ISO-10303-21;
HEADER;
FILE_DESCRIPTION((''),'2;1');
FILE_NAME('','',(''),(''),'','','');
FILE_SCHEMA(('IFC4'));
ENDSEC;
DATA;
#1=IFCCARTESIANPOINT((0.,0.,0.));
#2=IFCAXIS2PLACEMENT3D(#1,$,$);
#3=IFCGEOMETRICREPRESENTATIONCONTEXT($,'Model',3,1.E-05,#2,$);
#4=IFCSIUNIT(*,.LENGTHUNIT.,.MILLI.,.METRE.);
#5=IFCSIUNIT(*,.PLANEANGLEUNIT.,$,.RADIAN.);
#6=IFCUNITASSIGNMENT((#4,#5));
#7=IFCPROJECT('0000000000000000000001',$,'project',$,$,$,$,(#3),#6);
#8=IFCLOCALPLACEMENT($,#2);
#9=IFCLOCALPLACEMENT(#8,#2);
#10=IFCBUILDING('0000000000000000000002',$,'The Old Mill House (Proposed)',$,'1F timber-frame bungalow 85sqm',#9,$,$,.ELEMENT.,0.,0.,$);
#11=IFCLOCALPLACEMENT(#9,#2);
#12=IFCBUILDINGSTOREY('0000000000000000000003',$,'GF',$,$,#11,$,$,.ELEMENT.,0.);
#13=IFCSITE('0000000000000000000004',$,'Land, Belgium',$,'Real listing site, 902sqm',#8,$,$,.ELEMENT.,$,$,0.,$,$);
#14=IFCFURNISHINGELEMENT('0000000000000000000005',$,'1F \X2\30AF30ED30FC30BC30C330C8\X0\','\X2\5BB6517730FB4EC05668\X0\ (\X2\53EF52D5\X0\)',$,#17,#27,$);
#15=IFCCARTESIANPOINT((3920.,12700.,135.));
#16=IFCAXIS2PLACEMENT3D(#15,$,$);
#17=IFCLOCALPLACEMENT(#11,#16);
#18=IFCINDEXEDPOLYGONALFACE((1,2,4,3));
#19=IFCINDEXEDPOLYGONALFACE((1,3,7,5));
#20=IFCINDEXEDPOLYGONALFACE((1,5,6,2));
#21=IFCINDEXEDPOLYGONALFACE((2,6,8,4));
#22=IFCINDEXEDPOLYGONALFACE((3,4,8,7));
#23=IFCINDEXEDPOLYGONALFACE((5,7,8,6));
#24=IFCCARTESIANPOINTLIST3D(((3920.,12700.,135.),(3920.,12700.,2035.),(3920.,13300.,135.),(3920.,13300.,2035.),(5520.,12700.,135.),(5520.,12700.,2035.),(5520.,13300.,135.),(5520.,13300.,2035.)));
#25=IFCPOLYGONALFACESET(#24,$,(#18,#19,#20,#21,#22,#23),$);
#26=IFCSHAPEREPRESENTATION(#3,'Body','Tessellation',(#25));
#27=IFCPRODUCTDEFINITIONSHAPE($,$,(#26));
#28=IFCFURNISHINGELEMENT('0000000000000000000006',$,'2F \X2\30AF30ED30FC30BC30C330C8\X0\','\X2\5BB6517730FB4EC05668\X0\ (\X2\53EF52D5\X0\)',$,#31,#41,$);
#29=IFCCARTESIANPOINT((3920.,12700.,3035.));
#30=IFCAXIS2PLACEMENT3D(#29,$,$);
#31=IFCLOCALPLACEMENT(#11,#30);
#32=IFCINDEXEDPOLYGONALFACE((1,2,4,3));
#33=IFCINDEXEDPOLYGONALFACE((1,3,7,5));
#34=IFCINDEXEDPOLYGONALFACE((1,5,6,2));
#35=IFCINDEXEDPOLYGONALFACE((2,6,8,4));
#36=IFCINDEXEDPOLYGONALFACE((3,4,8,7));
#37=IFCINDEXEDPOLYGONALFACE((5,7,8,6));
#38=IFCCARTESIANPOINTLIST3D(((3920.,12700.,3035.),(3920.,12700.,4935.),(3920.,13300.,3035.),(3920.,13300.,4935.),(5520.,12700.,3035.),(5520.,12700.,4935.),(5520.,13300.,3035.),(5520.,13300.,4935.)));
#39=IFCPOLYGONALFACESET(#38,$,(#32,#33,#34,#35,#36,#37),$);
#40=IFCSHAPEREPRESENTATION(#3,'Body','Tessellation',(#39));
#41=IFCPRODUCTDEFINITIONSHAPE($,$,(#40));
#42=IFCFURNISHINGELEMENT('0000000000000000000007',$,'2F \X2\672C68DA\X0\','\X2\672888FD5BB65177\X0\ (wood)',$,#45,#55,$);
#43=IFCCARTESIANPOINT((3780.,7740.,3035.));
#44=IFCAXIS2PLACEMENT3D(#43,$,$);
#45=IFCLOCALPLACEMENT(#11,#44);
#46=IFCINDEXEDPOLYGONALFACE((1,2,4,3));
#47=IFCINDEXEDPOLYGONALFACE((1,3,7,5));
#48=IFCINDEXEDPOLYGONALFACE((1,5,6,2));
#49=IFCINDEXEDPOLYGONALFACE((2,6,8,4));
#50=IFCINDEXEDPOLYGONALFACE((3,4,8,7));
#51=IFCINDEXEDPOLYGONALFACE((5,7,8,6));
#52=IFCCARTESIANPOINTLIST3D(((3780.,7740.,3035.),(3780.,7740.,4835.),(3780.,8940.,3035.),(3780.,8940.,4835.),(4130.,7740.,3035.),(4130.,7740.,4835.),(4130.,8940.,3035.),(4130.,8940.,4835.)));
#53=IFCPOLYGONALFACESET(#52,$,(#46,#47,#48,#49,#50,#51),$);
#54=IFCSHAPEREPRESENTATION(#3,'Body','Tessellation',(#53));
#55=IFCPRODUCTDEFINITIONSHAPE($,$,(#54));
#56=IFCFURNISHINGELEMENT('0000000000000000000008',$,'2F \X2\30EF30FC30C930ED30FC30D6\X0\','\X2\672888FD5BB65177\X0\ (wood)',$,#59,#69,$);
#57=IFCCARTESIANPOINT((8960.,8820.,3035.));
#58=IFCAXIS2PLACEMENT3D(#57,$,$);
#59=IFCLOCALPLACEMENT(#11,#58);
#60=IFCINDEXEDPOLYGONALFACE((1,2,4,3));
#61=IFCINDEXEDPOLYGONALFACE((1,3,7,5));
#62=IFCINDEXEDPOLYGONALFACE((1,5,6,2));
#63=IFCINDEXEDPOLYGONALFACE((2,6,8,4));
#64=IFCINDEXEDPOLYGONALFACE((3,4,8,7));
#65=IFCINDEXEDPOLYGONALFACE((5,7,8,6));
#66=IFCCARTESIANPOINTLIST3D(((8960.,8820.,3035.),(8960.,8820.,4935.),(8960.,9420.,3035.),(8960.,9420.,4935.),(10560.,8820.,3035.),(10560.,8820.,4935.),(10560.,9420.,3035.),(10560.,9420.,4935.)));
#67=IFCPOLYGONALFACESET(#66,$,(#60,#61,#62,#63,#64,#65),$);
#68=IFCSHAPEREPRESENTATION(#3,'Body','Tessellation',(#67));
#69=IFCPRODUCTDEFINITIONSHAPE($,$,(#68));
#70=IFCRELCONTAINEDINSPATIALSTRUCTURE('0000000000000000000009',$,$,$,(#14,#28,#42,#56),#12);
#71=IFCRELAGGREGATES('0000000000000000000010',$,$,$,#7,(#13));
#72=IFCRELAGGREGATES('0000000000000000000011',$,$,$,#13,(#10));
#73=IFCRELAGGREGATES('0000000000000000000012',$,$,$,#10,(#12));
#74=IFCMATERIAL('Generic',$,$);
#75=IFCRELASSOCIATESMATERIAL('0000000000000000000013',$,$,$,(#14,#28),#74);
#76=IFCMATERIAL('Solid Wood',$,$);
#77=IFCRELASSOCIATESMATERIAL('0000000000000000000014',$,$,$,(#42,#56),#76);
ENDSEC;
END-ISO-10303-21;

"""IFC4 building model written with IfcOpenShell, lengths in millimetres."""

from ifc_helpers import new_model, si_unit, frame, frame_2d, origin, place, context, project, spatial, rectangle, extrude, material, element, save


model = new_model("IFC4")

# Units and contexts
model_context = context("Model", 3, precision=1e-05, world=origin())
ifc_project = project(units=[si_unit("LENGTHUNIT", "METRE", prefix="MILLI"), si_unit("PLANEANGLEUNIT", "RADIAN")], contexts=[model_context])

# Site, building, storey
site_placement = place(None, origin())
site = spatial("IfcSite", under=ifc_project, at=site_placement, Name="Land, Belgium", ObjectType="Real listing site, 902sqm", CompositionType="ELEMENT", RefElevation=0.0)
building_placement = place(site_placement, origin())
building = spatial("IfcBuilding", under=site, at=building_placement, Name="The Old Mill House (Proposed)", ObjectType="1F timber-frame bungalow 85sqm", CompositionType="ELEMENT", ElevationOfRefHeight=0.0, ElevationOfTerrain=0.0)
storey_placement = place(building_placement, origin())
storey = spatial("IfcBuildingStorey", under=building, at=storey_placement, Name="GF", CompositionType="ELEMENT", Elevation=0.0)

# Shared definitions
ifc_material_1 = material(Name="Solid Wood")

# Shared definitions
ifc_material_2 = material(Name="Generic")

# Furnishing elements
furnishing_1_placement = place(storey_placement, frame((3920.0, 12700.0, 135.0)))
element("IfcFurnishingElement", 1, at=furnishing_1_placement, inside=storey, material=ifc_material_2, Name="1F クローゼット", Description="家具・什器 (可動)", context=model_context, shape_type="SweptSolid", body=[
    extrude(rectangle(XDim=1600.0, YDim=600.0, at=frame_2d((800.0, 300.0))), frame((3920.0, 12700.0, 135.0)), (0.0, 0.0, 1.0), 1900.0),
])
furnishing_2_placement = place(storey_placement, frame((3920.0, 12700.0, 3035.0)))
element("IfcFurnishingElement", 2, at=furnishing_2_placement, inside=storey, material=ifc_material_2, Name="2F クローゼット", Description="家具・什器 (可動)", context=model_context, shape_type="SweptSolid", body=[
    extrude(rectangle(XDim=1600.0, YDim=600.0, at=frame_2d((800.0, 300.0))), frame((3920.0, 12700.0, 3035.0)), (0.0, 0.0, 1.0), 1900.0),
])
furnishing_3_placement = place(storey_placement, frame((3780.0, 7740.0, 3035.0)))
element("IfcFurnishingElement", 3, at=furnishing_3_placement, inside=storey, material=ifc_material_1, Name="2F 本棚", Description="木製家具 (wood)", context=model_context, shape_type="SweptSolid", body=[
    extrude(rectangle(XDim=350.0, YDim=1200.0, at=frame_2d((175.0, 600.0))), frame((3780.0, 7740.0, 3035.0)), (0.0, 0.0, 1.0), 1800.0),
])
furnishing_4_placement = place(storey_placement, frame((8960.0, 8820.0, 3035.0)))
element("IfcFurnishingElement", 4, at=furnishing_4_placement, inside=storey, material=ifc_material_1, Name="2F ワードローブ", Description="木製家具 (wood)", context=model_context, shape_type="SweptSolid", body=[
    extrude(rectangle(XDim=1600.0, YDim=600.0, at=frame_2d((800.0, 300.0))), frame((8960.0, 8820.0, 3035.0)), (0.0, 0.0, 1.0), 1900.0),
])

save(model, "model.ifc")
